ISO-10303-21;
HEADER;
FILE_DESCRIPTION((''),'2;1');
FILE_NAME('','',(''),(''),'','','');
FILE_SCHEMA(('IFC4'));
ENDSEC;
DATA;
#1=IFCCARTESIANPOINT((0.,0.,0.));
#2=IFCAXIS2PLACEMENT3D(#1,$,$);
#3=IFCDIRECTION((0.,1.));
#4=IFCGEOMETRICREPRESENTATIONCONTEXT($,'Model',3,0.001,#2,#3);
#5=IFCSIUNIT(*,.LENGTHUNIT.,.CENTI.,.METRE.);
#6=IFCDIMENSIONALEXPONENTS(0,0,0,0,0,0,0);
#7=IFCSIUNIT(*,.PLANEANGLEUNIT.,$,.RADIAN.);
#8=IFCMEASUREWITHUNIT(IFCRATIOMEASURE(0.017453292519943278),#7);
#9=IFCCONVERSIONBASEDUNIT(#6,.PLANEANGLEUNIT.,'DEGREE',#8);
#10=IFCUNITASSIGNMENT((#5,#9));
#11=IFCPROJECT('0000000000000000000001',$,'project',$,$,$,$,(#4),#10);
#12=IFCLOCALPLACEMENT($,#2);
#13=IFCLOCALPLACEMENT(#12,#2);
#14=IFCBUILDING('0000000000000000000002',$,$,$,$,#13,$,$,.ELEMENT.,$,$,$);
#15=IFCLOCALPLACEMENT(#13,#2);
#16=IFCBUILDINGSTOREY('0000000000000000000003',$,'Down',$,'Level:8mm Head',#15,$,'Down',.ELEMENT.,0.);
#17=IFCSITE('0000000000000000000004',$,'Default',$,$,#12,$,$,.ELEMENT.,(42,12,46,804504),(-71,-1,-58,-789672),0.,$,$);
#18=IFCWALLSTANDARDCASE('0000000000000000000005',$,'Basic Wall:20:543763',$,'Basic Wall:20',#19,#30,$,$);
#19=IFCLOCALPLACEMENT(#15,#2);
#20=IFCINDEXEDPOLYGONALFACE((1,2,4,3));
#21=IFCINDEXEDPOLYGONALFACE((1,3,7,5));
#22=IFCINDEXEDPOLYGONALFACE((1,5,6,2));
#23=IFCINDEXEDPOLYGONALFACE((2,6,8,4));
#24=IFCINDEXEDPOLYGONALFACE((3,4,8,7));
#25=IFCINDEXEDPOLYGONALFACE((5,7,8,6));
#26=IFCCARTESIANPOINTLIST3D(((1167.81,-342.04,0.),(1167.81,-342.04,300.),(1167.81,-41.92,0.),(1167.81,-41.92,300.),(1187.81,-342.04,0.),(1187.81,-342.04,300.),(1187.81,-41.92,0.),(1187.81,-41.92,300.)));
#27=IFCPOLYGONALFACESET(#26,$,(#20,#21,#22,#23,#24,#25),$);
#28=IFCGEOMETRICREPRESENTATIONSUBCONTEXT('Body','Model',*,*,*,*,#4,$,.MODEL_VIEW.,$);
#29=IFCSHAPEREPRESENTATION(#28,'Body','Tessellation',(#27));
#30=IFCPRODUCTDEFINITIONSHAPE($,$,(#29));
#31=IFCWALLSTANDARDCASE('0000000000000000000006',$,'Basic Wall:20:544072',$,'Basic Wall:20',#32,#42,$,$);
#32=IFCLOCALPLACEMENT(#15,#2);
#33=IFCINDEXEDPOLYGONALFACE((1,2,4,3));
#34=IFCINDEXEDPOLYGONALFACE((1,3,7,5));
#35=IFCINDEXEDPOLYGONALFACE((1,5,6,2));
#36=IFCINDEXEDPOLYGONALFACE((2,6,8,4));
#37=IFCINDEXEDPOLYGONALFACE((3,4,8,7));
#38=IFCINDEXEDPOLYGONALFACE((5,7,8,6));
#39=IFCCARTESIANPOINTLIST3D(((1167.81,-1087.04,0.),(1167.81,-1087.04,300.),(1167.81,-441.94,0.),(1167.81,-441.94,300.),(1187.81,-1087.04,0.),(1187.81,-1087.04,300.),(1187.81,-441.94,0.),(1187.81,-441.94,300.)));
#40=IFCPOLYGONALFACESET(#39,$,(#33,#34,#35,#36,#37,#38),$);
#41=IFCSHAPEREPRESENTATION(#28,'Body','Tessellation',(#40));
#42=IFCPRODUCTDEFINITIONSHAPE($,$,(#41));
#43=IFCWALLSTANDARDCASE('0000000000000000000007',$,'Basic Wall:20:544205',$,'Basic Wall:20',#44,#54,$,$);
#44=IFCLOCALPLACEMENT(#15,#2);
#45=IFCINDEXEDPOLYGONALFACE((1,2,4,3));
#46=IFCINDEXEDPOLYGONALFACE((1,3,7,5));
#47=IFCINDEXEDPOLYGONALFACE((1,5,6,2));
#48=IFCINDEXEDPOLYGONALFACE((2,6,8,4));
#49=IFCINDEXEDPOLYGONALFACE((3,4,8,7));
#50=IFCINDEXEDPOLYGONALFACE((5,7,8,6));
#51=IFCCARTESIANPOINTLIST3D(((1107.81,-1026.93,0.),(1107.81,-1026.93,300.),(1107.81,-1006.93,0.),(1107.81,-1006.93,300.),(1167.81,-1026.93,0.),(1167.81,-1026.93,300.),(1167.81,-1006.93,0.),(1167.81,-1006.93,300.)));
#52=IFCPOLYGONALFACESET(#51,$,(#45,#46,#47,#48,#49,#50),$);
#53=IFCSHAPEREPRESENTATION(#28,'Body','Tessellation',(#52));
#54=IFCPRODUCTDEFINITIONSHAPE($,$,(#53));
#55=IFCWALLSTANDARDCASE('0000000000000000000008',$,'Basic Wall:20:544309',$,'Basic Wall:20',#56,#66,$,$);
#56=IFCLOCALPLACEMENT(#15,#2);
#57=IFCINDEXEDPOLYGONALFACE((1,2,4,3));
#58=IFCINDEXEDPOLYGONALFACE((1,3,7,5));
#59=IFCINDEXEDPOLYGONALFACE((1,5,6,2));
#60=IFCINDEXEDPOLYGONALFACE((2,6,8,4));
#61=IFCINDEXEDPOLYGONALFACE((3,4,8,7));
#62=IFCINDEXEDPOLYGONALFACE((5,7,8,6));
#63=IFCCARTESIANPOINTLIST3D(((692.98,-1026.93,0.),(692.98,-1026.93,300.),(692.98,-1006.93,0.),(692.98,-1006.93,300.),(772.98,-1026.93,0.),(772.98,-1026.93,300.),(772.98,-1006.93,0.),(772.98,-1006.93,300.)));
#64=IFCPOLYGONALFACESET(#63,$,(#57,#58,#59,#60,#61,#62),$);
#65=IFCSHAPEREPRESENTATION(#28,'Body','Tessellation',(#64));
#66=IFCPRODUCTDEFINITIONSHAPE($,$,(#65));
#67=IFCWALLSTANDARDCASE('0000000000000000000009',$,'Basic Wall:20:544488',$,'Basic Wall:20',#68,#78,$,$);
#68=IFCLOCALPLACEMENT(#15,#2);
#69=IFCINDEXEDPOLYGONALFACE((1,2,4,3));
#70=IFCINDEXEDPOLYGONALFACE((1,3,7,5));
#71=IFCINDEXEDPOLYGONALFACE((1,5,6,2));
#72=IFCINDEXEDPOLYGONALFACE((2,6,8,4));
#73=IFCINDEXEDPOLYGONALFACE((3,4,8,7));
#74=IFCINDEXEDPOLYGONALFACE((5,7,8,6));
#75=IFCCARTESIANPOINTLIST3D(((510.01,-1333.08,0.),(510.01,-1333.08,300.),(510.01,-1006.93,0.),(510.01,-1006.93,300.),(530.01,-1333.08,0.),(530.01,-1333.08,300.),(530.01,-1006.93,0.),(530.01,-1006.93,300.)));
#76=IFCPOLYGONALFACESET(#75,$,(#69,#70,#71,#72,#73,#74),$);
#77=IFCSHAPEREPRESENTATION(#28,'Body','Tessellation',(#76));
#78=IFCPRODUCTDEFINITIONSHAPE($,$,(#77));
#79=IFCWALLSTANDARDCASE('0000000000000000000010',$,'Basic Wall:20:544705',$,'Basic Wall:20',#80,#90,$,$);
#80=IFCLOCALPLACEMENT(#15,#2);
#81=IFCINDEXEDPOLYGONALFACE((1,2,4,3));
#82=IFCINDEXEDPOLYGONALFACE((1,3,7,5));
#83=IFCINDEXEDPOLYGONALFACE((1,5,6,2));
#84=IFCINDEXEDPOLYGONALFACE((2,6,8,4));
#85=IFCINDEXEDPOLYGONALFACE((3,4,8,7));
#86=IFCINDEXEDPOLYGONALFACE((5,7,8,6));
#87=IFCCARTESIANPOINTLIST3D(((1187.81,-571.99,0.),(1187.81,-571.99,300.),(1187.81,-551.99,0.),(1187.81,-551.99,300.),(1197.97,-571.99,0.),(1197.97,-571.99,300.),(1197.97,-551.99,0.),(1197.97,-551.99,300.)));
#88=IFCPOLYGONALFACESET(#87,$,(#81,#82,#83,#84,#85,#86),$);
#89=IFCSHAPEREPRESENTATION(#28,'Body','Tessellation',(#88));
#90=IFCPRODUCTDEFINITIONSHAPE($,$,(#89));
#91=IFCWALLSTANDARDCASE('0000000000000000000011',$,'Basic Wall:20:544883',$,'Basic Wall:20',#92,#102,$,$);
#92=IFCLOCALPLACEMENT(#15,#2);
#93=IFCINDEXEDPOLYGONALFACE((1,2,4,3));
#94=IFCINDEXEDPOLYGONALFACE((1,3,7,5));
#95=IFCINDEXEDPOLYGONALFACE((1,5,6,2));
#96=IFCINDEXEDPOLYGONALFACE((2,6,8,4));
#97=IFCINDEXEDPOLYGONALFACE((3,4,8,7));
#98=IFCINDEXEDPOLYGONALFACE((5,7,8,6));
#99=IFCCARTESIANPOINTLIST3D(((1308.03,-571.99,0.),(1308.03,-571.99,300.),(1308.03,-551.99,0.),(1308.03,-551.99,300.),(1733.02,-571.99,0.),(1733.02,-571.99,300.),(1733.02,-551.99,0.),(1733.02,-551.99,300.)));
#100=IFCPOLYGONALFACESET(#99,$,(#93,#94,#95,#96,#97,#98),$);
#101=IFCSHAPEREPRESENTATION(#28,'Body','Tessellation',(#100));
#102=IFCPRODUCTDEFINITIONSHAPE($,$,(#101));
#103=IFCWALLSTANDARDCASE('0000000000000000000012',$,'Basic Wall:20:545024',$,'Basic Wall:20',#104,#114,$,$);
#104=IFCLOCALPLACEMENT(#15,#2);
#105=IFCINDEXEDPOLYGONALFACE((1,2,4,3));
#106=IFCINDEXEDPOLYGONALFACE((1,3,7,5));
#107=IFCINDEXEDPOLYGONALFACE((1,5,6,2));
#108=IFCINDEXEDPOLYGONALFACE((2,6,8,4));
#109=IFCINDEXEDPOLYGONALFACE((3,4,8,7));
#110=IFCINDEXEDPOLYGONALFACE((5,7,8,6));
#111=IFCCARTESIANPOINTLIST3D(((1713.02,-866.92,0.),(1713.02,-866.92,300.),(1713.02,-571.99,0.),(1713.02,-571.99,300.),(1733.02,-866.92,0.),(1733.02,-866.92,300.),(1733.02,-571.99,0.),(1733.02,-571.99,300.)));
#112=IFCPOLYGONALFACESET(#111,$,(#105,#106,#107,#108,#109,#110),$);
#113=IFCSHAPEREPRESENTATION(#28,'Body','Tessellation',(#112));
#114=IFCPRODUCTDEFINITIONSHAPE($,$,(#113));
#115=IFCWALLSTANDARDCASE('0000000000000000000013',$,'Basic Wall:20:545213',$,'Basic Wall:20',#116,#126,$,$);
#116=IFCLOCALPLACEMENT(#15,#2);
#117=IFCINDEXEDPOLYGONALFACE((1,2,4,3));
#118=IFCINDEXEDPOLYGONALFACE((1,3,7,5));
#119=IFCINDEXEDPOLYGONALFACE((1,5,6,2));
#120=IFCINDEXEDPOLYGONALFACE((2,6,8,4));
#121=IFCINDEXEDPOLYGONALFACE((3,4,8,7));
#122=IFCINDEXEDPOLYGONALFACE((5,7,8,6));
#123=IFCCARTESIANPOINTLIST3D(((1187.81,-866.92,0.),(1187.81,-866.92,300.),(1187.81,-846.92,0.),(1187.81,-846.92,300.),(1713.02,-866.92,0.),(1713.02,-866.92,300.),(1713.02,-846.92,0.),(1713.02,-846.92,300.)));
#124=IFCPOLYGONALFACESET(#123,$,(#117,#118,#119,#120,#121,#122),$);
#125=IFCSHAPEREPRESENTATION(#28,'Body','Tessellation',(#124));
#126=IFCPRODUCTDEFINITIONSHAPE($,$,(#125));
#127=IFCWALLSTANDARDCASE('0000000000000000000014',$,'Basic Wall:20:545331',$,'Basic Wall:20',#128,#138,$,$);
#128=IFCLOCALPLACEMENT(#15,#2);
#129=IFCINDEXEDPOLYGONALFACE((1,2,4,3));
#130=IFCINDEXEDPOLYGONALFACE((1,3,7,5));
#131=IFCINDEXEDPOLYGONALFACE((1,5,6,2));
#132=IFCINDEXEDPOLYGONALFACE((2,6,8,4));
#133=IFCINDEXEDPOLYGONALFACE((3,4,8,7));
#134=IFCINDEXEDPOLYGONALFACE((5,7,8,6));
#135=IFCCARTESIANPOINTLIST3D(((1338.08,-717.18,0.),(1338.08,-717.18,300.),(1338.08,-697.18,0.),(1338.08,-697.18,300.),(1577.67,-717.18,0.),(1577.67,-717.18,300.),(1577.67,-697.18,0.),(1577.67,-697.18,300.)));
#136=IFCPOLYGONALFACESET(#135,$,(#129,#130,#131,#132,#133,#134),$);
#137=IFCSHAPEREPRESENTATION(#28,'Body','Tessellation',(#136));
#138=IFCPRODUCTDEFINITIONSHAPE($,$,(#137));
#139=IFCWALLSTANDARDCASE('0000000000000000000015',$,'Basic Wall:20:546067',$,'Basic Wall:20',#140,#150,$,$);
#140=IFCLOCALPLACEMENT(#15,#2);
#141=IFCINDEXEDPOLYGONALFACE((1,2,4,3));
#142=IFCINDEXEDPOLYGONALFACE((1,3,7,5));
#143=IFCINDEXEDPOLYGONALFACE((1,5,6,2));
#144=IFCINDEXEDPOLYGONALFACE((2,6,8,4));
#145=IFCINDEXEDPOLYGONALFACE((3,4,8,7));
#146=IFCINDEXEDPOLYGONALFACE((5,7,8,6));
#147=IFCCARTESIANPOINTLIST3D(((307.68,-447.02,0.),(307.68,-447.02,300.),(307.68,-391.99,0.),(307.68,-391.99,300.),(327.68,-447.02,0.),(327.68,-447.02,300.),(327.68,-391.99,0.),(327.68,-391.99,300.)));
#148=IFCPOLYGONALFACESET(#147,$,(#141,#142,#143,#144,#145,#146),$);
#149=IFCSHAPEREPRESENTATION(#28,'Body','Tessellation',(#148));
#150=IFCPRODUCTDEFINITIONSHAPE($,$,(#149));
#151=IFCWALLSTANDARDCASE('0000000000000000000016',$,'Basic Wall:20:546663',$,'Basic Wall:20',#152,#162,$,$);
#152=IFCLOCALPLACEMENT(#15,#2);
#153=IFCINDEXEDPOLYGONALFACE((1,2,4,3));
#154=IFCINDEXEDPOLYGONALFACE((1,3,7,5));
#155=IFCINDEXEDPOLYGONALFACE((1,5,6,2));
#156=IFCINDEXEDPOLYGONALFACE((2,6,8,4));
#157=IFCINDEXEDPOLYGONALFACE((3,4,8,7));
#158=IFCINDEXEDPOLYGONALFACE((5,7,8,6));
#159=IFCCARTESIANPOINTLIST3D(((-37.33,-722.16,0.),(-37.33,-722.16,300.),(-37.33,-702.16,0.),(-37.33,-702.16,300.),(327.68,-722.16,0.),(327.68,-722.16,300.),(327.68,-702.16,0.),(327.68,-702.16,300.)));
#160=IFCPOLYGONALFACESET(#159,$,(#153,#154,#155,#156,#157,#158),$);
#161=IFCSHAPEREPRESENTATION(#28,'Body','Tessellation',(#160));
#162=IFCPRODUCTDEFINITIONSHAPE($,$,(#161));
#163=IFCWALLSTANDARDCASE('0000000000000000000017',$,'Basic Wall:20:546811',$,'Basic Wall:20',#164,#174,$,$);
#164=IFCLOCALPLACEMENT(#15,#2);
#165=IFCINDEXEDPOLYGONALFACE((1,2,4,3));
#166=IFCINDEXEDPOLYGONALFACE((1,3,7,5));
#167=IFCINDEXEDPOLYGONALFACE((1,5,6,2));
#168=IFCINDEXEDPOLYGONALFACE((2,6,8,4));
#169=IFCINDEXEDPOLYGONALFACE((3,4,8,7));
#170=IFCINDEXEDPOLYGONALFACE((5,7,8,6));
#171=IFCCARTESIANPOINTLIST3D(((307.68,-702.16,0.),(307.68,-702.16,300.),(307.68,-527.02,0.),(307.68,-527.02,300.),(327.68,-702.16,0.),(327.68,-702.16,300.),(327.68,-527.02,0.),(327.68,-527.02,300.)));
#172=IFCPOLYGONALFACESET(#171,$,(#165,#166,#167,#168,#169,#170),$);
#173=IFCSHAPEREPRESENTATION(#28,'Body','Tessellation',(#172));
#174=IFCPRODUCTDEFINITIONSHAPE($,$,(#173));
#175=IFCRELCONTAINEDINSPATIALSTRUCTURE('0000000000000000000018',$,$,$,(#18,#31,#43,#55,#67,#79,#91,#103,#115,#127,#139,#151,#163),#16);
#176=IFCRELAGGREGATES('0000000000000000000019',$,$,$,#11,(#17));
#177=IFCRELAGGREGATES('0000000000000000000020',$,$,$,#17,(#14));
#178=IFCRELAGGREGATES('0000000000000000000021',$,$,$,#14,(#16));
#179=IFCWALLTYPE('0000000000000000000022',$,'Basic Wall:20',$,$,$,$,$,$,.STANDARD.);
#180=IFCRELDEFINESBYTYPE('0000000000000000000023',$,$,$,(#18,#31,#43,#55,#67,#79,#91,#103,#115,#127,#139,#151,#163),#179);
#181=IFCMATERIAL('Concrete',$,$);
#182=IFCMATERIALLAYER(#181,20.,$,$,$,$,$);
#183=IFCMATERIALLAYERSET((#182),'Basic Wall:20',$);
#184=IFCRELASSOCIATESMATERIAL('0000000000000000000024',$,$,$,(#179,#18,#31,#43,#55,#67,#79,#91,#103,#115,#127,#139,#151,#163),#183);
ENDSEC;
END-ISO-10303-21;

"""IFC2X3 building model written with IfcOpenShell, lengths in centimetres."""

from ifc_helpers import new_model, entity, si_unit, converted_unit, direction, frame, frame_2d, origin, place, context, subcontext, project, spatial, rectangle, extrude, material, layer, layer_set, layer_usage, type_object, element, save


model = new_model("IFC2X3")

# Units and contexts
model_context = context("Model", 3, precision=0.001, world=origin(), true_north=direction((0.0, 1.0)))
body_context = subcontext(model_context, "Body", "Model", "MODEL_VIEW")
ifc_project = project(units=[si_unit("LENGTHUNIT", "METRE", prefix="CENTI"), converted_unit("PLANEANGLEUNIT", "DEGREE", entity("IfcRatioMeasure", 0.017453292519943278), si_unit("PLANEANGLEUNIT", "RADIAN"), dimensions=[0, 0, 0, 0, 0, 0, 0])], contexts=[model_context])

# Site, building, storey
site_placement = place(None, origin())
site = spatial("IfcSite", under=ifc_project, at=site_placement, Name="Default", CompositionType="ELEMENT", RefLatitude=(42, 12, 46, 804504), RefLongitude=(-71, -1, -58, -789672), RefElevation=0.0)
building_placement = place(site_placement, origin())
building = spatial("IfcBuilding", under=site, at=building_placement, CompositionType="ELEMENT")
storey_placement = place(building_placement, origin())
storey = spatial("IfcBuildingStorey", under=building, at=storey_placement, Name="Down", ObjectType="Level:8mm Head", LongName="Down", CompositionType="ELEMENT", Elevation=0.0)

# Shared definitions
ifc_material = material(Name="Concrete")

# Walls
ifc_layer_1 = layer(ifc_material, 20.0)
ifc_layer_set_1 = layer_set([ifc_layer_1], Name="Basic Wall:20")
wall_type_1 = type_object("IfcWallType", Name="Basic Wall:20", PredefinedType="STANDARD", material=ifc_layer_set_1)
ifc_layer_usage_1 = layer_usage(ifc_layer_set_1, "AXIS2", "NEGATIVE", 10.0)
wall_1_placement = place(storey_placement, frame((1177.81, -41.92, 0.0), z_axis=(0.0, 0.0, 1.0), x_axis=(0.0, -1.0, 0.0)))
element("IfcWallStandardCase", 1, at=wall_1_placement, inside=storey, type_object=wall_type_1, material=ifc_layer_usage_1, Name="Basic Wall:20:543763", ObjectType="Basic Wall:20", context=body_context, shape_type="SweptSolid", body=[
    extrude(rectangle(XDim=300.12, YDim=20.0, at=frame_2d((150.06, 0.0), x_axis=(-1.0, 0.0))), origin(), (0.0, 0.0, 1.0), 300.0),
])
ifc_layer_usage_2 = layer_usage(ifc_layer_set_1, "AXIS2", "NEGATIVE", 10.0)
wall_2_placement = place(storey_placement, frame((1177.81, -441.94, 0.0), z_axis=(0.0, 0.0, 1.0), x_axis=(0.0, -1.0, 0.0)))
element("IfcWallStandardCase", 2, at=wall_2_placement, inside=storey, type_object=wall_type_1, material=ifc_layer_usage_2, Name="Basic Wall:20:544072", ObjectType="Basic Wall:20", context=body_context, shape_type="SweptSolid", body=[
    extrude(rectangle(XDim=645.1, YDim=20.0, at=frame_2d((322.55, 0.0), x_axis=(-1.0, 0.0))), origin(), (0.0, 0.0, 1.0), 300.0),
])
ifc_layer_usage_3 = layer_usage(ifc_layer_set_1, "AXIS2", "NEGATIVE", 10.0)
wall_3_placement = place(storey_placement, frame((1167.81, -1016.93, 0.0), z_axis=(0.0, 0.0, 1.0), x_axis=(-1.0, 0.0, 0.0)))
element("IfcWallStandardCase", 3, at=wall_3_placement, inside=storey, type_object=wall_type_1, material=ifc_layer_usage_3, Name="Basic Wall:20:544205", ObjectType="Basic Wall:20", context=body_context, shape_type="SweptSolid", body=[
    extrude(rectangle(XDim=60.0, YDim=20.0, at=frame_2d((30.0, 0.0), x_axis=(-1.0, 0.0))), origin(), (0.0, 0.0, 1.0), 300.0),
])
ifc_layer_usage_4 = layer_usage(ifc_layer_set_1, "AXIS2", "NEGATIVE", 10.0)
wall_4_placement = place(storey_placement, frame((772.98, -1016.93, 0.0), z_axis=(0.0, 0.0, 1.0), x_axis=(-1.0, 0.0, 0.0)))
element("IfcWallStandardCase", 4, at=wall_4_placement, inside=storey, type_object=wall_type_1, material=ifc_layer_usage_4, Name="Basic Wall:20:544309", ObjectType="Basic Wall:20", context=body_context, shape_type="SweptSolid", body=[
    extrude(rectangle(XDim=80.0, YDim=20.0, at=frame_2d((40.0, 0.0), x_axis=(-1.0, 0.0))), origin(), (0.0, 0.0, 1.0), 300.0),
])
ifc_layer_usage_5 = layer_usage(ifc_layer_set_1, "AXIS2", "NEGATIVE", 10.0)
wall_5_placement = place(storey_placement, frame((520.01, -1006.93, 0.0), z_axis=(0.0, 0.0, 1.0), x_axis=(0.0, -1.0, 0.0)))
element("IfcWallStandardCase", 5, at=wall_5_placement, inside=storey, type_object=wall_type_1, material=ifc_layer_usage_5, Name="Basic Wall:20:544488", ObjectType="Basic Wall:20", context=body_context, shape_type="SweptSolid", body=[
    extrude(rectangle(XDim=326.15, YDim=20.0, at=frame_2d((163.07, 0.0), x_axis=(-1.0, 0.0))), origin(), (0.0, 0.0, 1.0), 300.0),
])
ifc_layer_usage_6 = layer_usage(ifc_layer_set_1, "AXIS2", "NEGATIVE", 10.0)
wall_6_placement = place(storey_placement, frame((1187.81, -561.99, 0.0)))
element("IfcWallStandardCase", 6, at=wall_6_placement, inside=storey, type_object=wall_type_1, material=ifc_layer_usage_6, Name="Basic Wall:20:544705", ObjectType="Basic Wall:20", context=body_context, shape_type="SweptSolid", body=[
    extrude(rectangle(XDim=10.16, YDim=20.0, at=frame_2d((5.08, 0.0), x_axis=(-1.0, 0.0))), origin(), (0.0, 0.0, 1.0), 300.0),
])
ifc_layer_usage_7 = layer_usage(ifc_layer_set_1, "AXIS2", "NEGATIVE", 10.0)
wall_7_placement = place(storey_placement, frame((1308.03, -561.99, 0.0)))
element("IfcWallStandardCase", 7, at=wall_7_placement, inside=storey, type_object=wall_type_1, material=ifc_layer_usage_7, Name="Basic Wall:20:544883", ObjectType="Basic Wall:20", context=body_context, shape_type="SweptSolid", body=[
    extrude(rectangle(XDim=424.99, YDim=20.0, at=frame_2d((212.49, 0.0), x_axis=(-1.0, 0.0))), origin(), (0.0, 0.0, 1.0), 300.0),
])
ifc_layer_usage_8 = layer_usage(ifc_layer_set_1, "AXIS2", "NEGATIVE", 10.0)
wall_8_placement = place(storey_placement, frame((1723.02, -571.99, 0.0), z_axis=(0.0, 0.0, 1.0), x_axis=(0.0, -1.0, 0.0)))
element("IfcWallStandardCase", 8, at=wall_8_placement, inside=storey, type_object=wall_type_1, material=ifc_layer_usage_8, Name="Basic Wall:20:545024", ObjectType="Basic Wall:20", context=body_context, shape_type="SweptSolid", body=[
    extrude(rectangle(XDim=294.93, YDim=20.0, at=frame_2d((147.47, 0.0), x_axis=(-1.0, 0.0))), origin(), (0.0, 0.0, 1.0), 300.0),
])
ifc_layer_usage_9 = layer_usage(ifc_layer_set_1, "AXIS2", "NEGATIVE", 10.0)
wall_9_placement = place(storey_placement, frame((1713.02, -856.92, 0.0), z_axis=(0.0, 0.0, 1.0), x_axis=(-1.0, 0.0, 0.0)))
element("IfcWallStandardCase", 9, at=wall_9_placement, inside=storey, type_object=wall_type_1, material=ifc_layer_usage_9, Name="Basic Wall:20:545213", ObjectType="Basic Wall:20", context=body_context, shape_type="SweptSolid", body=[
    extrude(rectangle(XDim=525.2, YDim=20.0, at=frame_2d((262.6, 0.0), x_axis=(-1.0, 0.0))), origin(), (0.0, 0.0, 1.0), 300.0),
])
ifc_layer_usage_10 = layer_usage(ifc_layer_set_1, "AXIS2", "POSITIVE", -10.0)
wall_10_placement = place(storey_placement, frame((1577.67, -707.18, 0.0), z_axis=(0.0, 0.0, 1.0), x_axis=(-1.0, 0.0, 0.0)))
element("IfcWallStandardCase", 10, at=wall_10_placement, inside=storey, type_object=wall_type_1, material=ifc_layer_usage_10, Name="Basic Wall:20:545331", ObjectType="Basic Wall:20", context=body_context, shape_type="SweptSolid", body=[
    extrude(rectangle(XDim=239.58, YDim=20.0, at=frame_2d((119.79, 0.0), x_axis=(-1.0, 0.0))), origin(), (0.0, 0.0, 1.0), 300.0),
])
ifc_layer_usage_11 = layer_usage(ifc_layer_set_1, "AXIS2", "NEGATIVE", 10.0)
wall_11_placement = place(storey_placement, frame((317.68, -391.99, 0.0), z_axis=(0.0, 0.0, 1.0), x_axis=(0.0, -1.0, 0.0)))
element("IfcWallStandardCase", 11, at=wall_11_placement, inside=storey, type_object=wall_type_1, material=ifc_layer_usage_11, Name="Basic Wall:20:546067", ObjectType="Basic Wall:20", context=body_context, shape_type="SweptSolid", body=[
    extrude(rectangle(XDim=55.03, YDim=20.0, at=frame_2d((27.51, 0.0), x_axis=(-1.0, 0.0))), origin(), (0.0, 0.0, 1.0), 300.0),
])
ifc_layer_usage_12 = layer_usage(ifc_layer_set_1, "AXIS2", "POSITIVE", -10.0)
wall_12_placement = place(storey_placement, frame((-37.33, -712.16, 0.0)))
element("IfcWallStandardCase", 12, at=wall_12_placement, inside=storey, type_object=wall_type_1, material=ifc_layer_usage_12, Name="Basic Wall:20:546663", ObjectType="Basic Wall:20", context=body_context, shape_type="SweptSolid", body=[
    extrude(rectangle(XDim=365.01, YDim=20.0, at=frame_2d((182.51, 0.0), x_axis=(-1.0, 0.0))), origin(), (0.0, 0.0, 1.0), 300.0),
])
ifc_layer_usage_13 = layer_usage(ifc_layer_set_1, "AXIS2", "POSITIVE", -10.0)
wall_13_placement = place(storey_placement, frame((317.68, -702.16, 0.0), z_axis=(0.0, 0.0, 1.0), x_axis=(0.0, 1.0, 0.0)))
element("IfcWallStandardCase", 13, at=wall_13_placement, inside=storey, type_object=wall_type_1, material=ifc_layer_usage_13, Name="Basic Wall:20:546811", ObjectType="Basic Wall:20", context=body_context, shape_type="SweptSolid", body=[
    extrude(rectangle(XDim=175.14, YDim=20.0, at=frame_2d((87.57, 0.0), x_axis=(-1.0, 0.0))), origin(), (0.0, 0.0, 1.0), 300.0),
])

save(model, "model.ifc")
